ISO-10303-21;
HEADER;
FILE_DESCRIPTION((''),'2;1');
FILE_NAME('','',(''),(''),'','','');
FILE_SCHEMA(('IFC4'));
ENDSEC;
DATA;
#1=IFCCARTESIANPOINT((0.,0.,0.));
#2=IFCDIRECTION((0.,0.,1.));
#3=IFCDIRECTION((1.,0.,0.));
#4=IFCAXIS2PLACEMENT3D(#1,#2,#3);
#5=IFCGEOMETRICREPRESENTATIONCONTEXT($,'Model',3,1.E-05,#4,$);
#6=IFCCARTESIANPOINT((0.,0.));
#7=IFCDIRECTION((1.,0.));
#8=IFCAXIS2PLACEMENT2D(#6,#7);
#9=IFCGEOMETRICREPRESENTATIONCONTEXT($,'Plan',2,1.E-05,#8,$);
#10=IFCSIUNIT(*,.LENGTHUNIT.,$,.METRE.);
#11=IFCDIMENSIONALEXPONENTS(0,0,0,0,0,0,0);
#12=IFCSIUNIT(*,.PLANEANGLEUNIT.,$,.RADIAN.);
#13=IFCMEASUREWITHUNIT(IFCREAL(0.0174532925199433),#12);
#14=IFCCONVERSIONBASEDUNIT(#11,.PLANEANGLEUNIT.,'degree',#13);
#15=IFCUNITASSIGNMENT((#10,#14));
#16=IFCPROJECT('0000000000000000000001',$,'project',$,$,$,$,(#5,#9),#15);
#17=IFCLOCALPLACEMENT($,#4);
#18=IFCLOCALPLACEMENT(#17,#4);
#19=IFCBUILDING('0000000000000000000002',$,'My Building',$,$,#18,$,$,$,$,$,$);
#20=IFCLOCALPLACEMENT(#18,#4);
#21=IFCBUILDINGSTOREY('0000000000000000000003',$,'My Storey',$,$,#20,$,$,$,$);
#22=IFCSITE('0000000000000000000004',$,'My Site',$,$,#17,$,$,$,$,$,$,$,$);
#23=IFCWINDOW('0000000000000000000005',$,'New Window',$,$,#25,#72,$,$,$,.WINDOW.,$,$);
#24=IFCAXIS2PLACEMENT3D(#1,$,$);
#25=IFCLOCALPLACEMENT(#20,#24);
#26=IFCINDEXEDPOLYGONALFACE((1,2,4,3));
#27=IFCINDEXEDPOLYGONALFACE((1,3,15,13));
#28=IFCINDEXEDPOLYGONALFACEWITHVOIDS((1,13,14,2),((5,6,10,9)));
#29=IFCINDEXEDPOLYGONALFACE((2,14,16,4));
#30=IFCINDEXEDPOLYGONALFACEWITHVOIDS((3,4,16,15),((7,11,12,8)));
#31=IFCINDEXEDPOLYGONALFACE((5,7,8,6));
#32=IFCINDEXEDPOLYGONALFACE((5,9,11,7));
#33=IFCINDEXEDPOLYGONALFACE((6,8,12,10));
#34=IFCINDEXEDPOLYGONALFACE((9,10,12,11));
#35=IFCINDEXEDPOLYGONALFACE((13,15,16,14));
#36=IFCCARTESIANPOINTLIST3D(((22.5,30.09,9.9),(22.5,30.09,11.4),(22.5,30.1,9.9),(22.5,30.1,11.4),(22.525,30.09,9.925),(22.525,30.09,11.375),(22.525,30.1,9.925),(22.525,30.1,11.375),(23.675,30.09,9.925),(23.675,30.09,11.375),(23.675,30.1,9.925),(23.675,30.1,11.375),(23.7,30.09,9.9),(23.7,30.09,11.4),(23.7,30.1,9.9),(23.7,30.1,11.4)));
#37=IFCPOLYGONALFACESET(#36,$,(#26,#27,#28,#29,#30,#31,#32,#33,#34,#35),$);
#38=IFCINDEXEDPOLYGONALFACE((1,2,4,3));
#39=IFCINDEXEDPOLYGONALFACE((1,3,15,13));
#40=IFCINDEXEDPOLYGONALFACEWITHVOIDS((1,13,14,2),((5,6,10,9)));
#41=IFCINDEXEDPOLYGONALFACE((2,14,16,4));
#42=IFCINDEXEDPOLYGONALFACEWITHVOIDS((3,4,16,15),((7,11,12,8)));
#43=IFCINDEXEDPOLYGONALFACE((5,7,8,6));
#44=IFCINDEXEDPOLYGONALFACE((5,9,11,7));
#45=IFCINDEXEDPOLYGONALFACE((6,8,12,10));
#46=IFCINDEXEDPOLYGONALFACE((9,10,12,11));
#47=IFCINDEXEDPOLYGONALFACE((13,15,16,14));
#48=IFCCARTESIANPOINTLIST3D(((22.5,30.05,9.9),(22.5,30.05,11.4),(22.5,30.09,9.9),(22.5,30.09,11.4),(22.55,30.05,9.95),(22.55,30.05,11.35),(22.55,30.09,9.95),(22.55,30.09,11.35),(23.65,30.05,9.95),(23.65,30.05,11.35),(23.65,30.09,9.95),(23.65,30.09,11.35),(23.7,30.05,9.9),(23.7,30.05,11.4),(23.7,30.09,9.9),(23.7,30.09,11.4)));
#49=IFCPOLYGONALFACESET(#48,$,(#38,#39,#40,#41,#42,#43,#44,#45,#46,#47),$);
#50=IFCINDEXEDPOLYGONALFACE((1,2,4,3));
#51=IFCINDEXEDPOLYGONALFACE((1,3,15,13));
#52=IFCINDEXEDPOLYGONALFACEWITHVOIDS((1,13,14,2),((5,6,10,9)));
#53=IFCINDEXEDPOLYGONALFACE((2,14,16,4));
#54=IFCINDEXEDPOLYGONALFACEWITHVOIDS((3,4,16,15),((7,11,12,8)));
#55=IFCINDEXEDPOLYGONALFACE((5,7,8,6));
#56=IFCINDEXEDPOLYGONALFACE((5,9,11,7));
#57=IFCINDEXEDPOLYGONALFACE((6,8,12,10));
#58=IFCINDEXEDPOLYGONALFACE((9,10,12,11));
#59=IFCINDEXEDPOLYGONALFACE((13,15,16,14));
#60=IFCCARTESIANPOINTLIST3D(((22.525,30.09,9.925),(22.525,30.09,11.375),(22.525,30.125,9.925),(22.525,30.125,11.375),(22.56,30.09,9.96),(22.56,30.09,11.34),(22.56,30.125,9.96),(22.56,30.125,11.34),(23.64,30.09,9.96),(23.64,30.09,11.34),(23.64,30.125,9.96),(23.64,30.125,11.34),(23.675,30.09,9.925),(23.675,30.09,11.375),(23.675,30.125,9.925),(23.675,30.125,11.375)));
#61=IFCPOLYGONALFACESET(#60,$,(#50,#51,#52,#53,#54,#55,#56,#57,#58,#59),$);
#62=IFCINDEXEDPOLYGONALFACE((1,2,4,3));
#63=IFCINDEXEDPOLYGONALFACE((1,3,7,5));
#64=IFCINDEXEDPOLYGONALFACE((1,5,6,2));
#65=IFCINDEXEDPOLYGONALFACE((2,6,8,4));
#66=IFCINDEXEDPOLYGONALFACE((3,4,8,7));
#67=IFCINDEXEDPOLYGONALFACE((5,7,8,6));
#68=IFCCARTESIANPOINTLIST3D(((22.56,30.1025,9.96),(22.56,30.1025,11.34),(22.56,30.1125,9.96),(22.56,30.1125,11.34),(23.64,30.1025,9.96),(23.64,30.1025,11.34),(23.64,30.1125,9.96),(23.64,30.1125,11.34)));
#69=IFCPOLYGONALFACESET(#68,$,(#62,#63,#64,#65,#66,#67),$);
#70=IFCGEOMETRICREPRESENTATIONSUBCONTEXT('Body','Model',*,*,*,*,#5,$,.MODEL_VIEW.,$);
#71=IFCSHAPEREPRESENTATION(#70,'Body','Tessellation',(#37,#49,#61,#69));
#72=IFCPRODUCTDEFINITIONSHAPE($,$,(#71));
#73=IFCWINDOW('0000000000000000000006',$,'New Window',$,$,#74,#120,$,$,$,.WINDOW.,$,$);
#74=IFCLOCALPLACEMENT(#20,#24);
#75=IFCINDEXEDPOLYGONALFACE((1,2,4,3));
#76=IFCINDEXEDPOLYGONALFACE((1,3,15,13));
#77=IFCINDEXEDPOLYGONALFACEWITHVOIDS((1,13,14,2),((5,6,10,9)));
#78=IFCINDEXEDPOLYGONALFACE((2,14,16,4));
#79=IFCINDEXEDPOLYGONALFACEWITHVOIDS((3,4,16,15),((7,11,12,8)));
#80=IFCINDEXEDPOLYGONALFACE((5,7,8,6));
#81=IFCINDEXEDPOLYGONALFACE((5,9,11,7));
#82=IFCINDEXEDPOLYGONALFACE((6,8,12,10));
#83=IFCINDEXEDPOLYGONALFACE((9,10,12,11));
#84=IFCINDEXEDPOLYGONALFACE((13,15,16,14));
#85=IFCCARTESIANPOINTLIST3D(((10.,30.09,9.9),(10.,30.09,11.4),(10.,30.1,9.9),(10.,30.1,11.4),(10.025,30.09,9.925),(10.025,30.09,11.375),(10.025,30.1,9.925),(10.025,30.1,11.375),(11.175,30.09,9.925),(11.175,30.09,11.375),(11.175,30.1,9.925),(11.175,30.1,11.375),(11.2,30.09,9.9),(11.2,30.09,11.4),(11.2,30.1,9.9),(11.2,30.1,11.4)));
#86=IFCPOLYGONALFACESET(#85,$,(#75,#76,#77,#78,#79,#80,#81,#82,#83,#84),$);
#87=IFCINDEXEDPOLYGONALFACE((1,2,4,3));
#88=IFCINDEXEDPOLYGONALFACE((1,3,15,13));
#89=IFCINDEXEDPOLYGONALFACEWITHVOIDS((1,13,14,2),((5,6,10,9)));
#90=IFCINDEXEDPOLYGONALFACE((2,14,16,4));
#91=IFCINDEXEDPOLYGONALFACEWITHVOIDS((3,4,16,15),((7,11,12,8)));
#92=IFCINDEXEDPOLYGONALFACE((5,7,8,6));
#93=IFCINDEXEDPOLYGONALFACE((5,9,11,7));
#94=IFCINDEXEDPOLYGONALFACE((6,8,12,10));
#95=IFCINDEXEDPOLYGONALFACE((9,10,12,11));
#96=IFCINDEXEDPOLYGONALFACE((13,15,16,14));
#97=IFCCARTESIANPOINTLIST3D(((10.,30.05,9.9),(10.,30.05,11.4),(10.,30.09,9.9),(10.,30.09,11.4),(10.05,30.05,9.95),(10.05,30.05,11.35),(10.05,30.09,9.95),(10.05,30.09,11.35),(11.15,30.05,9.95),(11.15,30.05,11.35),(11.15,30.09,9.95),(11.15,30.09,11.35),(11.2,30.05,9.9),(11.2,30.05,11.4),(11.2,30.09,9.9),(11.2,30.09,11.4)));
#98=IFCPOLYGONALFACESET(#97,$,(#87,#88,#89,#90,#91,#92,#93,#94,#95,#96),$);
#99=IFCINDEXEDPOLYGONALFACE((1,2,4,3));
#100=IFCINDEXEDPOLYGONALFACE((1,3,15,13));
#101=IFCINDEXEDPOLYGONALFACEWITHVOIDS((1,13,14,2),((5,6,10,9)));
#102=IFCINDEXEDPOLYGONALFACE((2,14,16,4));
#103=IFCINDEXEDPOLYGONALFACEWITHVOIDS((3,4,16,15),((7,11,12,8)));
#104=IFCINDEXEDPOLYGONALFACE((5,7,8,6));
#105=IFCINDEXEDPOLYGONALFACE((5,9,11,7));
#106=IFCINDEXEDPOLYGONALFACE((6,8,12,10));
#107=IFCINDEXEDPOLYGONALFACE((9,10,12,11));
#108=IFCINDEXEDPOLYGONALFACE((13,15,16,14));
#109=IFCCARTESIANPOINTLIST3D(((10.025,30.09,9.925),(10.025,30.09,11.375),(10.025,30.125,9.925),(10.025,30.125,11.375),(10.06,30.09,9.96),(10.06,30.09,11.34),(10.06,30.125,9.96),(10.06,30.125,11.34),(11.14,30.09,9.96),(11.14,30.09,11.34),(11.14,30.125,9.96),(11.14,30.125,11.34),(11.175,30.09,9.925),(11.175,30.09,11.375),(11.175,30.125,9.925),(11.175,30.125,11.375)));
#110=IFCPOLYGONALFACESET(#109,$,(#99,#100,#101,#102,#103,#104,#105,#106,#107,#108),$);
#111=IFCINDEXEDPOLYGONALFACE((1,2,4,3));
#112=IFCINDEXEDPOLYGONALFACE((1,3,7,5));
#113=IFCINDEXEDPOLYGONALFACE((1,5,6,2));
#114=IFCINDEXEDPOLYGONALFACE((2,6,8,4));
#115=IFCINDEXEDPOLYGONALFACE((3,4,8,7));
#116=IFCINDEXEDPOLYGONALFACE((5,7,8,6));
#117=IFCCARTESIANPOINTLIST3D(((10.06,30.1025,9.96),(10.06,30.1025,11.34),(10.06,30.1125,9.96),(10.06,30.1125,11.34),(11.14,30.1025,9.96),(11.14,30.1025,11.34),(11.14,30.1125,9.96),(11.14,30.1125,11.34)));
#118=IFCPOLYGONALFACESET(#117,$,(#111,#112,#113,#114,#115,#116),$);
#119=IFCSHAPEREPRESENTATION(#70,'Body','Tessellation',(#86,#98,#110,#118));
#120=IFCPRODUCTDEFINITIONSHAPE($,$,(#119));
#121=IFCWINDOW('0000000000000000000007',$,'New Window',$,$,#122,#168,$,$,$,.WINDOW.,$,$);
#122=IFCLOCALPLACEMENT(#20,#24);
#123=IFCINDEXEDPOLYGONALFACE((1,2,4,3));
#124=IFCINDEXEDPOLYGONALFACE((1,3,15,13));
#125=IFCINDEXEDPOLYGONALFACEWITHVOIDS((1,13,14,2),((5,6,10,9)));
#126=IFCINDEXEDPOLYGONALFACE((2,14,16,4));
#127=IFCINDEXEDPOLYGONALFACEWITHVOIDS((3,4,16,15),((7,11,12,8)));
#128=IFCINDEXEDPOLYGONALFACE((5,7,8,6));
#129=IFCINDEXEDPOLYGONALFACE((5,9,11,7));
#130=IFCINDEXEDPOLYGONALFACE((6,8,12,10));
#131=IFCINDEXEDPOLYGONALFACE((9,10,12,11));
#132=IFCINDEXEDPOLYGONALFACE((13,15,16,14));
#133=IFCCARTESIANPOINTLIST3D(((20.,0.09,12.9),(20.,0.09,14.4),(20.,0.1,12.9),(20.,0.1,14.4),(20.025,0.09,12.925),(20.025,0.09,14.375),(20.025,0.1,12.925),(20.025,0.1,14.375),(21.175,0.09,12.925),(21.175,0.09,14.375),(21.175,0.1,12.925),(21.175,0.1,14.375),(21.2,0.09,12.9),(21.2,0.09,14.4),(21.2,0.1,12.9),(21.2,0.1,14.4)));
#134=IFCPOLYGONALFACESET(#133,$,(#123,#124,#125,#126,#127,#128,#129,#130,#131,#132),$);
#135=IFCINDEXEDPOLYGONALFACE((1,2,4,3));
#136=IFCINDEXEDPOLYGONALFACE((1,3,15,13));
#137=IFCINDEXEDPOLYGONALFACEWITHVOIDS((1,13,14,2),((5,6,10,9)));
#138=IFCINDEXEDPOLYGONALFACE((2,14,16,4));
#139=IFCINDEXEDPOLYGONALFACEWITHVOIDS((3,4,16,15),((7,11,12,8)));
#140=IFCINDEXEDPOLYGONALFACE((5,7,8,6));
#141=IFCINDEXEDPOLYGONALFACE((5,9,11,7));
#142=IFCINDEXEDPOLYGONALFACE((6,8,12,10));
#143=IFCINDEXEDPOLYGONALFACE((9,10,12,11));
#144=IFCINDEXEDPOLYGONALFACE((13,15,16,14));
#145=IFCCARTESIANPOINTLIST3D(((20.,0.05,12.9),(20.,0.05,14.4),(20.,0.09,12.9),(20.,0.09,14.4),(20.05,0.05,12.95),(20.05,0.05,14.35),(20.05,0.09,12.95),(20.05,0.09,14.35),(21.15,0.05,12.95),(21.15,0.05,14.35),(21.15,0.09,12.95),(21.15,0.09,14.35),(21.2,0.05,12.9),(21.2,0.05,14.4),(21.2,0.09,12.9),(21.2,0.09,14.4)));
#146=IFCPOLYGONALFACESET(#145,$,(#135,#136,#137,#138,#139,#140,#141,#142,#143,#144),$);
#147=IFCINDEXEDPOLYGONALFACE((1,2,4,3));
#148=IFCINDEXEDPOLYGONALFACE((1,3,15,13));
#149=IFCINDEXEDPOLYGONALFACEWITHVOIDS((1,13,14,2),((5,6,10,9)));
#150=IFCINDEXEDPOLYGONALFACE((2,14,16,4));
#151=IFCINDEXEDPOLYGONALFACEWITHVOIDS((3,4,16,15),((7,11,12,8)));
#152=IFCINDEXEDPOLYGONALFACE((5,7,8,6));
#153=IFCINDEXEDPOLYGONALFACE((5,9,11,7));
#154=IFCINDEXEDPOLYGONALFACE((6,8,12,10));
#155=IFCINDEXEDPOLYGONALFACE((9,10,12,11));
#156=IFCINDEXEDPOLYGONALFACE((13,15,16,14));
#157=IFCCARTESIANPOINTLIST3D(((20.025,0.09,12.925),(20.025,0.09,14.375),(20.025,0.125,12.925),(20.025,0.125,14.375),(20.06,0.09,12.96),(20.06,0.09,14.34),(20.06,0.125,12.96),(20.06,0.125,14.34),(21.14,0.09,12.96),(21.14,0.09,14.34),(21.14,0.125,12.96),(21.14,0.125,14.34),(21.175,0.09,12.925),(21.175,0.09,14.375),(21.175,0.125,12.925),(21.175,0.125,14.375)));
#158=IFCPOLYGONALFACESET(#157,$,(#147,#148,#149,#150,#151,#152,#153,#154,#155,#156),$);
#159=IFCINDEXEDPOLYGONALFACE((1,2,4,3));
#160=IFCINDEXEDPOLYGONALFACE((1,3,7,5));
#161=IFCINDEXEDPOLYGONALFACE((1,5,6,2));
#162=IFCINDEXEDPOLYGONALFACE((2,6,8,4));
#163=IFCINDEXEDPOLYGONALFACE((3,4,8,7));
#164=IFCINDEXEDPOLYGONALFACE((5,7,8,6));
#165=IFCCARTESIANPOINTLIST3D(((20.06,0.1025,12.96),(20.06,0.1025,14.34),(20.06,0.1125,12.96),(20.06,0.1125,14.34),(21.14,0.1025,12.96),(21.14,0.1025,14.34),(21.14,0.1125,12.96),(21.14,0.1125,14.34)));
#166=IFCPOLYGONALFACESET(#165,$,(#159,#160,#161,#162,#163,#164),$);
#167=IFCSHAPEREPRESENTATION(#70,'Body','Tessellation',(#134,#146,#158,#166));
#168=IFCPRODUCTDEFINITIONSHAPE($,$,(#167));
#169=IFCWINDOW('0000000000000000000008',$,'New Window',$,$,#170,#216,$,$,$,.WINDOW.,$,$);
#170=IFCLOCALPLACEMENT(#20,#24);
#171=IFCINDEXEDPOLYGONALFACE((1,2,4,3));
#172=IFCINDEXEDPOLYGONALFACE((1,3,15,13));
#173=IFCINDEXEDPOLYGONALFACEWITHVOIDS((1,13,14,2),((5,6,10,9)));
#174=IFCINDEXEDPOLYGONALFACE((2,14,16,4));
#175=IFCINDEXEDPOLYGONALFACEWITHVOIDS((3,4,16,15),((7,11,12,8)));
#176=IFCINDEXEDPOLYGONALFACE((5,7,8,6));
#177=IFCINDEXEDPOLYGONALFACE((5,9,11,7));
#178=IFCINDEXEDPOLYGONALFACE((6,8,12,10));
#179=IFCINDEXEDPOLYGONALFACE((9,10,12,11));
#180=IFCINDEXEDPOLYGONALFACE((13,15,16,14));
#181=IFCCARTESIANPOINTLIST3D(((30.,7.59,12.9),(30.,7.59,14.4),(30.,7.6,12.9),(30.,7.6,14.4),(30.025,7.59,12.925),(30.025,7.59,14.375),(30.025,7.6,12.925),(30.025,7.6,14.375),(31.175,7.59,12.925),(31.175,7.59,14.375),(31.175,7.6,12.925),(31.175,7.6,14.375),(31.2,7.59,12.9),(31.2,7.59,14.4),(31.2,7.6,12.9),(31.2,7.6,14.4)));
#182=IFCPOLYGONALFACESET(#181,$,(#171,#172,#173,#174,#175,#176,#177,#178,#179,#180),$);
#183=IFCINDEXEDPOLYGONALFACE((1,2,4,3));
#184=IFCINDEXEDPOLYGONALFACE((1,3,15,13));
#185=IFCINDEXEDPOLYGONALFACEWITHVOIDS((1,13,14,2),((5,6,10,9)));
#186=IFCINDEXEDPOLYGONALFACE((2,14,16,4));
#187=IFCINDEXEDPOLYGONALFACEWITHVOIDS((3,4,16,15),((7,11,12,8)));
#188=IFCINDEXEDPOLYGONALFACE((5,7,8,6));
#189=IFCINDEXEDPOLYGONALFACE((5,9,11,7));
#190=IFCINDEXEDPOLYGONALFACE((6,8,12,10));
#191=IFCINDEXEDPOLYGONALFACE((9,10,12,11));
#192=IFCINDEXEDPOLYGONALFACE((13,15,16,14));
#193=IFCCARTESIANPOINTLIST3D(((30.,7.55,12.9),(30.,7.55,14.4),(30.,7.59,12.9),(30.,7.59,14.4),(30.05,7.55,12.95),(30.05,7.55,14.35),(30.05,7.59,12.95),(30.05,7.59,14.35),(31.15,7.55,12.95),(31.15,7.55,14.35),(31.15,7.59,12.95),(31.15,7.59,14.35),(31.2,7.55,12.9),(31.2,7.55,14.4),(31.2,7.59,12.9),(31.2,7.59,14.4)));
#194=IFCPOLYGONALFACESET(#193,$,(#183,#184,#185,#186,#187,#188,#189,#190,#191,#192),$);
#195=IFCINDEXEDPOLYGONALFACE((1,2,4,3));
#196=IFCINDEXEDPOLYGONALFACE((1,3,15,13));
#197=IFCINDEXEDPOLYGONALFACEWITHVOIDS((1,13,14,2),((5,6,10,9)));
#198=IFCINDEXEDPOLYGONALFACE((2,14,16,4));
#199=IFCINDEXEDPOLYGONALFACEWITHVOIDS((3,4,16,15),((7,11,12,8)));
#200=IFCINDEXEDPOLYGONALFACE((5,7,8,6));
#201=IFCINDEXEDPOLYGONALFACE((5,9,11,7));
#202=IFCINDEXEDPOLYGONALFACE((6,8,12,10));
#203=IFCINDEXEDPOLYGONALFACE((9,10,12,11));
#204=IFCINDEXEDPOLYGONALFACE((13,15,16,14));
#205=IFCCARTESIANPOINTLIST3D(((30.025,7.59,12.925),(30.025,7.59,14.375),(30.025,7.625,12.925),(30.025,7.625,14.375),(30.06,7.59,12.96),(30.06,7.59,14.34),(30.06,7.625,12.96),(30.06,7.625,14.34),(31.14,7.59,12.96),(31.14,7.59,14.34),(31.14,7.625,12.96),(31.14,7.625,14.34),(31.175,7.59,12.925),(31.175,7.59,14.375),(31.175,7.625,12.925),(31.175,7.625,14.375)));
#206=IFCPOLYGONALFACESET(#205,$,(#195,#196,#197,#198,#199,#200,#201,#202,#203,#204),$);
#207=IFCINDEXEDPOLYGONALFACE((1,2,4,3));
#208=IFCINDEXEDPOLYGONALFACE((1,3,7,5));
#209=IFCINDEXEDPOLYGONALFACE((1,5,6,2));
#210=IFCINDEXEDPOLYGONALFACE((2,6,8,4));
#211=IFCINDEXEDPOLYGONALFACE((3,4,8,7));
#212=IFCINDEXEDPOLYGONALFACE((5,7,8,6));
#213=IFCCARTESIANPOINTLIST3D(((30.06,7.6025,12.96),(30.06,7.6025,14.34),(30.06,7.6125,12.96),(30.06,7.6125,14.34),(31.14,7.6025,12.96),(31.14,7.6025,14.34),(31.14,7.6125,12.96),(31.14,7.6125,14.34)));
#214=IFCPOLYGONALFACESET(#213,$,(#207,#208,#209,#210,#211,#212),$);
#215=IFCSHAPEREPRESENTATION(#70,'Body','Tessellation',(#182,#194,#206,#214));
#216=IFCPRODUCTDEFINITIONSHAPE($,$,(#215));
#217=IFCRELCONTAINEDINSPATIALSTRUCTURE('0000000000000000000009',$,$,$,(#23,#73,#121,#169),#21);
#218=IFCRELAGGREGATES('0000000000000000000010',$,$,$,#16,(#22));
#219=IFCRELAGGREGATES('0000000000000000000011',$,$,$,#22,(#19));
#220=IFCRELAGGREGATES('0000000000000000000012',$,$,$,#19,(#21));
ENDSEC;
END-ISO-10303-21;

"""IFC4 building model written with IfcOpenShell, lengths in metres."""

from ifc_helpers import new_model, entity, si_unit, converted_unit, frame, origin_with_axes, origin_2d_with_axis, place, context, subcontext, project, spatial, line, indexed_curve, outline, extrude, element, save


model = new_model("IFC4")

# Units and contexts
model_context = context("Model", 3, precision=1e-05, world=origin_with_axes())
plan_context = context("Plan", 2, precision=1e-05, world=origin_2d_with_axis())
body_context = subcontext(model_context, "Body", "Model", "MODEL_VIEW")
ifc_project = project(units=[si_unit("LENGTHUNIT", "METRE"), converted_unit("PLANEANGLEUNIT", "degree", entity("IfcReal", 0.0174532925199433), si_unit("PLANEANGLEUNIT", "RADIAN"), dimensions=[0, 0, 0, 0, 0, 0, 0])], contexts=[model_context, plan_context])

# Site, building, storey
site_placement = place(None, origin_with_axes())
site = spatial("IfcSite", under=ifc_project, at=site_placement, Name="My Site")
building_placement = place(site_placement, origin_with_axes())
building = spatial("IfcBuilding", under=site, at=building_placement, Name="My Building")
storey_placement = place(building_placement, origin_with_axes())
storey = spatial("IfcBuildingStorey", under=building, at=storey_placement, Name="My Storey")

# Windows
for number, where, z_axis, x_axis, name in (
    (1, (22.5, 30.0, 9.9), (0.0, 0.0, 1.0), (1.0, 0.0, 0.0), "New Window"),
    (2, (10.0, 30.0, 9.9), (0.0, 0.0, 1.0), (1.0, 0.0, 0.0), "New Window"),
    (3, (20.0, 0.0, 12.9), (0.0, 0.0, 1.0), (1.0, 0.0, 0.0), "New Window"),
    (4, (30.0, 7.5, 12.9), (0.0, 0.0, 1.0), (1.0, 0.0, 0.0), "New Window"),
):
    element("IfcWindow", number, at=place(storey_placement, frame(where, z_axis=z_axis, x_axis=x_axis)), inside=storey, Name=name, PredefinedType="WINDOW", context=body_context, shape_type="SweptSolid", body=[
        extrude(outline(indexed_curve([(0.0, 0.0), (1.2, 0.0), (1.2, 1.5), (0.0, 1.5)], segments=[line(1, 2, 3, 4, 1)]), holes=[indexed_curve([(0.025, 0.025), (1.175, 0.025), (1.175, 1.475), (0.025, 1.475)], segments=[line(1, 2, 3, 4, 1)])]), frame((0.0, 0.09, 0.0), z_axis=(0.0, -1.0, 0.0), x_axis=(1.0, 0.0, 0.0)), (0.0, 0.0, -1.0), 0.01),
        extrude(outline(indexed_curve([(0.0, 0.0), (1.2, 0.0), (1.2, 1.5), (0.0, 1.5)], segments=[line(1, 2, 3, 4, 1)]), holes=[indexed_curve([(0.05, 0.05), (1.15, 0.05), (1.15, 1.45), (0.05, 1.45)], segments=[line(1, 2, 3, 4, 1)])]), frame((0.0, 0.05, 0.0), z_axis=(0.0, -1.0, 0.0), x_axis=(1.0, 0.0, 0.0)), (0.0, 0.0, -1.0), 0.04),
        extrude(outline(indexed_curve([(0.0, 0.0), (1.15, 0.0), (1.15, 1.45), (0.0, 1.45)], segments=[line(1, 2, 3, 4, 1)]), holes=[indexed_curve([(0.035, 0.035), (1.115, 0.035), (1.115, 1.415), (0.035, 1.415)], segments=[line(1, 2, 3, 4, 1)])]), frame((0.025, 0.09, 0.025), z_axis=(0.0, -1.0, 0.0), x_axis=(1.0, 0.0, 0.0)), (0.0, 0.0, -1.0), 0.035),
        extrude(outline(indexed_curve([(0.035, 0.035), (1.115, 0.035), (1.115, 1.415), (0.035, 1.415)], segments=[line(1, 2, 3, 4, 1)])), frame((0.025, 0.1025, 0.025), z_axis=(0.0, -1.0, 0.0), x_axis=(1.0, 0.0, 0.0)), (0.0, 0.0, -1.0), 0.01),
    ])

save(model, "model.ifc")
